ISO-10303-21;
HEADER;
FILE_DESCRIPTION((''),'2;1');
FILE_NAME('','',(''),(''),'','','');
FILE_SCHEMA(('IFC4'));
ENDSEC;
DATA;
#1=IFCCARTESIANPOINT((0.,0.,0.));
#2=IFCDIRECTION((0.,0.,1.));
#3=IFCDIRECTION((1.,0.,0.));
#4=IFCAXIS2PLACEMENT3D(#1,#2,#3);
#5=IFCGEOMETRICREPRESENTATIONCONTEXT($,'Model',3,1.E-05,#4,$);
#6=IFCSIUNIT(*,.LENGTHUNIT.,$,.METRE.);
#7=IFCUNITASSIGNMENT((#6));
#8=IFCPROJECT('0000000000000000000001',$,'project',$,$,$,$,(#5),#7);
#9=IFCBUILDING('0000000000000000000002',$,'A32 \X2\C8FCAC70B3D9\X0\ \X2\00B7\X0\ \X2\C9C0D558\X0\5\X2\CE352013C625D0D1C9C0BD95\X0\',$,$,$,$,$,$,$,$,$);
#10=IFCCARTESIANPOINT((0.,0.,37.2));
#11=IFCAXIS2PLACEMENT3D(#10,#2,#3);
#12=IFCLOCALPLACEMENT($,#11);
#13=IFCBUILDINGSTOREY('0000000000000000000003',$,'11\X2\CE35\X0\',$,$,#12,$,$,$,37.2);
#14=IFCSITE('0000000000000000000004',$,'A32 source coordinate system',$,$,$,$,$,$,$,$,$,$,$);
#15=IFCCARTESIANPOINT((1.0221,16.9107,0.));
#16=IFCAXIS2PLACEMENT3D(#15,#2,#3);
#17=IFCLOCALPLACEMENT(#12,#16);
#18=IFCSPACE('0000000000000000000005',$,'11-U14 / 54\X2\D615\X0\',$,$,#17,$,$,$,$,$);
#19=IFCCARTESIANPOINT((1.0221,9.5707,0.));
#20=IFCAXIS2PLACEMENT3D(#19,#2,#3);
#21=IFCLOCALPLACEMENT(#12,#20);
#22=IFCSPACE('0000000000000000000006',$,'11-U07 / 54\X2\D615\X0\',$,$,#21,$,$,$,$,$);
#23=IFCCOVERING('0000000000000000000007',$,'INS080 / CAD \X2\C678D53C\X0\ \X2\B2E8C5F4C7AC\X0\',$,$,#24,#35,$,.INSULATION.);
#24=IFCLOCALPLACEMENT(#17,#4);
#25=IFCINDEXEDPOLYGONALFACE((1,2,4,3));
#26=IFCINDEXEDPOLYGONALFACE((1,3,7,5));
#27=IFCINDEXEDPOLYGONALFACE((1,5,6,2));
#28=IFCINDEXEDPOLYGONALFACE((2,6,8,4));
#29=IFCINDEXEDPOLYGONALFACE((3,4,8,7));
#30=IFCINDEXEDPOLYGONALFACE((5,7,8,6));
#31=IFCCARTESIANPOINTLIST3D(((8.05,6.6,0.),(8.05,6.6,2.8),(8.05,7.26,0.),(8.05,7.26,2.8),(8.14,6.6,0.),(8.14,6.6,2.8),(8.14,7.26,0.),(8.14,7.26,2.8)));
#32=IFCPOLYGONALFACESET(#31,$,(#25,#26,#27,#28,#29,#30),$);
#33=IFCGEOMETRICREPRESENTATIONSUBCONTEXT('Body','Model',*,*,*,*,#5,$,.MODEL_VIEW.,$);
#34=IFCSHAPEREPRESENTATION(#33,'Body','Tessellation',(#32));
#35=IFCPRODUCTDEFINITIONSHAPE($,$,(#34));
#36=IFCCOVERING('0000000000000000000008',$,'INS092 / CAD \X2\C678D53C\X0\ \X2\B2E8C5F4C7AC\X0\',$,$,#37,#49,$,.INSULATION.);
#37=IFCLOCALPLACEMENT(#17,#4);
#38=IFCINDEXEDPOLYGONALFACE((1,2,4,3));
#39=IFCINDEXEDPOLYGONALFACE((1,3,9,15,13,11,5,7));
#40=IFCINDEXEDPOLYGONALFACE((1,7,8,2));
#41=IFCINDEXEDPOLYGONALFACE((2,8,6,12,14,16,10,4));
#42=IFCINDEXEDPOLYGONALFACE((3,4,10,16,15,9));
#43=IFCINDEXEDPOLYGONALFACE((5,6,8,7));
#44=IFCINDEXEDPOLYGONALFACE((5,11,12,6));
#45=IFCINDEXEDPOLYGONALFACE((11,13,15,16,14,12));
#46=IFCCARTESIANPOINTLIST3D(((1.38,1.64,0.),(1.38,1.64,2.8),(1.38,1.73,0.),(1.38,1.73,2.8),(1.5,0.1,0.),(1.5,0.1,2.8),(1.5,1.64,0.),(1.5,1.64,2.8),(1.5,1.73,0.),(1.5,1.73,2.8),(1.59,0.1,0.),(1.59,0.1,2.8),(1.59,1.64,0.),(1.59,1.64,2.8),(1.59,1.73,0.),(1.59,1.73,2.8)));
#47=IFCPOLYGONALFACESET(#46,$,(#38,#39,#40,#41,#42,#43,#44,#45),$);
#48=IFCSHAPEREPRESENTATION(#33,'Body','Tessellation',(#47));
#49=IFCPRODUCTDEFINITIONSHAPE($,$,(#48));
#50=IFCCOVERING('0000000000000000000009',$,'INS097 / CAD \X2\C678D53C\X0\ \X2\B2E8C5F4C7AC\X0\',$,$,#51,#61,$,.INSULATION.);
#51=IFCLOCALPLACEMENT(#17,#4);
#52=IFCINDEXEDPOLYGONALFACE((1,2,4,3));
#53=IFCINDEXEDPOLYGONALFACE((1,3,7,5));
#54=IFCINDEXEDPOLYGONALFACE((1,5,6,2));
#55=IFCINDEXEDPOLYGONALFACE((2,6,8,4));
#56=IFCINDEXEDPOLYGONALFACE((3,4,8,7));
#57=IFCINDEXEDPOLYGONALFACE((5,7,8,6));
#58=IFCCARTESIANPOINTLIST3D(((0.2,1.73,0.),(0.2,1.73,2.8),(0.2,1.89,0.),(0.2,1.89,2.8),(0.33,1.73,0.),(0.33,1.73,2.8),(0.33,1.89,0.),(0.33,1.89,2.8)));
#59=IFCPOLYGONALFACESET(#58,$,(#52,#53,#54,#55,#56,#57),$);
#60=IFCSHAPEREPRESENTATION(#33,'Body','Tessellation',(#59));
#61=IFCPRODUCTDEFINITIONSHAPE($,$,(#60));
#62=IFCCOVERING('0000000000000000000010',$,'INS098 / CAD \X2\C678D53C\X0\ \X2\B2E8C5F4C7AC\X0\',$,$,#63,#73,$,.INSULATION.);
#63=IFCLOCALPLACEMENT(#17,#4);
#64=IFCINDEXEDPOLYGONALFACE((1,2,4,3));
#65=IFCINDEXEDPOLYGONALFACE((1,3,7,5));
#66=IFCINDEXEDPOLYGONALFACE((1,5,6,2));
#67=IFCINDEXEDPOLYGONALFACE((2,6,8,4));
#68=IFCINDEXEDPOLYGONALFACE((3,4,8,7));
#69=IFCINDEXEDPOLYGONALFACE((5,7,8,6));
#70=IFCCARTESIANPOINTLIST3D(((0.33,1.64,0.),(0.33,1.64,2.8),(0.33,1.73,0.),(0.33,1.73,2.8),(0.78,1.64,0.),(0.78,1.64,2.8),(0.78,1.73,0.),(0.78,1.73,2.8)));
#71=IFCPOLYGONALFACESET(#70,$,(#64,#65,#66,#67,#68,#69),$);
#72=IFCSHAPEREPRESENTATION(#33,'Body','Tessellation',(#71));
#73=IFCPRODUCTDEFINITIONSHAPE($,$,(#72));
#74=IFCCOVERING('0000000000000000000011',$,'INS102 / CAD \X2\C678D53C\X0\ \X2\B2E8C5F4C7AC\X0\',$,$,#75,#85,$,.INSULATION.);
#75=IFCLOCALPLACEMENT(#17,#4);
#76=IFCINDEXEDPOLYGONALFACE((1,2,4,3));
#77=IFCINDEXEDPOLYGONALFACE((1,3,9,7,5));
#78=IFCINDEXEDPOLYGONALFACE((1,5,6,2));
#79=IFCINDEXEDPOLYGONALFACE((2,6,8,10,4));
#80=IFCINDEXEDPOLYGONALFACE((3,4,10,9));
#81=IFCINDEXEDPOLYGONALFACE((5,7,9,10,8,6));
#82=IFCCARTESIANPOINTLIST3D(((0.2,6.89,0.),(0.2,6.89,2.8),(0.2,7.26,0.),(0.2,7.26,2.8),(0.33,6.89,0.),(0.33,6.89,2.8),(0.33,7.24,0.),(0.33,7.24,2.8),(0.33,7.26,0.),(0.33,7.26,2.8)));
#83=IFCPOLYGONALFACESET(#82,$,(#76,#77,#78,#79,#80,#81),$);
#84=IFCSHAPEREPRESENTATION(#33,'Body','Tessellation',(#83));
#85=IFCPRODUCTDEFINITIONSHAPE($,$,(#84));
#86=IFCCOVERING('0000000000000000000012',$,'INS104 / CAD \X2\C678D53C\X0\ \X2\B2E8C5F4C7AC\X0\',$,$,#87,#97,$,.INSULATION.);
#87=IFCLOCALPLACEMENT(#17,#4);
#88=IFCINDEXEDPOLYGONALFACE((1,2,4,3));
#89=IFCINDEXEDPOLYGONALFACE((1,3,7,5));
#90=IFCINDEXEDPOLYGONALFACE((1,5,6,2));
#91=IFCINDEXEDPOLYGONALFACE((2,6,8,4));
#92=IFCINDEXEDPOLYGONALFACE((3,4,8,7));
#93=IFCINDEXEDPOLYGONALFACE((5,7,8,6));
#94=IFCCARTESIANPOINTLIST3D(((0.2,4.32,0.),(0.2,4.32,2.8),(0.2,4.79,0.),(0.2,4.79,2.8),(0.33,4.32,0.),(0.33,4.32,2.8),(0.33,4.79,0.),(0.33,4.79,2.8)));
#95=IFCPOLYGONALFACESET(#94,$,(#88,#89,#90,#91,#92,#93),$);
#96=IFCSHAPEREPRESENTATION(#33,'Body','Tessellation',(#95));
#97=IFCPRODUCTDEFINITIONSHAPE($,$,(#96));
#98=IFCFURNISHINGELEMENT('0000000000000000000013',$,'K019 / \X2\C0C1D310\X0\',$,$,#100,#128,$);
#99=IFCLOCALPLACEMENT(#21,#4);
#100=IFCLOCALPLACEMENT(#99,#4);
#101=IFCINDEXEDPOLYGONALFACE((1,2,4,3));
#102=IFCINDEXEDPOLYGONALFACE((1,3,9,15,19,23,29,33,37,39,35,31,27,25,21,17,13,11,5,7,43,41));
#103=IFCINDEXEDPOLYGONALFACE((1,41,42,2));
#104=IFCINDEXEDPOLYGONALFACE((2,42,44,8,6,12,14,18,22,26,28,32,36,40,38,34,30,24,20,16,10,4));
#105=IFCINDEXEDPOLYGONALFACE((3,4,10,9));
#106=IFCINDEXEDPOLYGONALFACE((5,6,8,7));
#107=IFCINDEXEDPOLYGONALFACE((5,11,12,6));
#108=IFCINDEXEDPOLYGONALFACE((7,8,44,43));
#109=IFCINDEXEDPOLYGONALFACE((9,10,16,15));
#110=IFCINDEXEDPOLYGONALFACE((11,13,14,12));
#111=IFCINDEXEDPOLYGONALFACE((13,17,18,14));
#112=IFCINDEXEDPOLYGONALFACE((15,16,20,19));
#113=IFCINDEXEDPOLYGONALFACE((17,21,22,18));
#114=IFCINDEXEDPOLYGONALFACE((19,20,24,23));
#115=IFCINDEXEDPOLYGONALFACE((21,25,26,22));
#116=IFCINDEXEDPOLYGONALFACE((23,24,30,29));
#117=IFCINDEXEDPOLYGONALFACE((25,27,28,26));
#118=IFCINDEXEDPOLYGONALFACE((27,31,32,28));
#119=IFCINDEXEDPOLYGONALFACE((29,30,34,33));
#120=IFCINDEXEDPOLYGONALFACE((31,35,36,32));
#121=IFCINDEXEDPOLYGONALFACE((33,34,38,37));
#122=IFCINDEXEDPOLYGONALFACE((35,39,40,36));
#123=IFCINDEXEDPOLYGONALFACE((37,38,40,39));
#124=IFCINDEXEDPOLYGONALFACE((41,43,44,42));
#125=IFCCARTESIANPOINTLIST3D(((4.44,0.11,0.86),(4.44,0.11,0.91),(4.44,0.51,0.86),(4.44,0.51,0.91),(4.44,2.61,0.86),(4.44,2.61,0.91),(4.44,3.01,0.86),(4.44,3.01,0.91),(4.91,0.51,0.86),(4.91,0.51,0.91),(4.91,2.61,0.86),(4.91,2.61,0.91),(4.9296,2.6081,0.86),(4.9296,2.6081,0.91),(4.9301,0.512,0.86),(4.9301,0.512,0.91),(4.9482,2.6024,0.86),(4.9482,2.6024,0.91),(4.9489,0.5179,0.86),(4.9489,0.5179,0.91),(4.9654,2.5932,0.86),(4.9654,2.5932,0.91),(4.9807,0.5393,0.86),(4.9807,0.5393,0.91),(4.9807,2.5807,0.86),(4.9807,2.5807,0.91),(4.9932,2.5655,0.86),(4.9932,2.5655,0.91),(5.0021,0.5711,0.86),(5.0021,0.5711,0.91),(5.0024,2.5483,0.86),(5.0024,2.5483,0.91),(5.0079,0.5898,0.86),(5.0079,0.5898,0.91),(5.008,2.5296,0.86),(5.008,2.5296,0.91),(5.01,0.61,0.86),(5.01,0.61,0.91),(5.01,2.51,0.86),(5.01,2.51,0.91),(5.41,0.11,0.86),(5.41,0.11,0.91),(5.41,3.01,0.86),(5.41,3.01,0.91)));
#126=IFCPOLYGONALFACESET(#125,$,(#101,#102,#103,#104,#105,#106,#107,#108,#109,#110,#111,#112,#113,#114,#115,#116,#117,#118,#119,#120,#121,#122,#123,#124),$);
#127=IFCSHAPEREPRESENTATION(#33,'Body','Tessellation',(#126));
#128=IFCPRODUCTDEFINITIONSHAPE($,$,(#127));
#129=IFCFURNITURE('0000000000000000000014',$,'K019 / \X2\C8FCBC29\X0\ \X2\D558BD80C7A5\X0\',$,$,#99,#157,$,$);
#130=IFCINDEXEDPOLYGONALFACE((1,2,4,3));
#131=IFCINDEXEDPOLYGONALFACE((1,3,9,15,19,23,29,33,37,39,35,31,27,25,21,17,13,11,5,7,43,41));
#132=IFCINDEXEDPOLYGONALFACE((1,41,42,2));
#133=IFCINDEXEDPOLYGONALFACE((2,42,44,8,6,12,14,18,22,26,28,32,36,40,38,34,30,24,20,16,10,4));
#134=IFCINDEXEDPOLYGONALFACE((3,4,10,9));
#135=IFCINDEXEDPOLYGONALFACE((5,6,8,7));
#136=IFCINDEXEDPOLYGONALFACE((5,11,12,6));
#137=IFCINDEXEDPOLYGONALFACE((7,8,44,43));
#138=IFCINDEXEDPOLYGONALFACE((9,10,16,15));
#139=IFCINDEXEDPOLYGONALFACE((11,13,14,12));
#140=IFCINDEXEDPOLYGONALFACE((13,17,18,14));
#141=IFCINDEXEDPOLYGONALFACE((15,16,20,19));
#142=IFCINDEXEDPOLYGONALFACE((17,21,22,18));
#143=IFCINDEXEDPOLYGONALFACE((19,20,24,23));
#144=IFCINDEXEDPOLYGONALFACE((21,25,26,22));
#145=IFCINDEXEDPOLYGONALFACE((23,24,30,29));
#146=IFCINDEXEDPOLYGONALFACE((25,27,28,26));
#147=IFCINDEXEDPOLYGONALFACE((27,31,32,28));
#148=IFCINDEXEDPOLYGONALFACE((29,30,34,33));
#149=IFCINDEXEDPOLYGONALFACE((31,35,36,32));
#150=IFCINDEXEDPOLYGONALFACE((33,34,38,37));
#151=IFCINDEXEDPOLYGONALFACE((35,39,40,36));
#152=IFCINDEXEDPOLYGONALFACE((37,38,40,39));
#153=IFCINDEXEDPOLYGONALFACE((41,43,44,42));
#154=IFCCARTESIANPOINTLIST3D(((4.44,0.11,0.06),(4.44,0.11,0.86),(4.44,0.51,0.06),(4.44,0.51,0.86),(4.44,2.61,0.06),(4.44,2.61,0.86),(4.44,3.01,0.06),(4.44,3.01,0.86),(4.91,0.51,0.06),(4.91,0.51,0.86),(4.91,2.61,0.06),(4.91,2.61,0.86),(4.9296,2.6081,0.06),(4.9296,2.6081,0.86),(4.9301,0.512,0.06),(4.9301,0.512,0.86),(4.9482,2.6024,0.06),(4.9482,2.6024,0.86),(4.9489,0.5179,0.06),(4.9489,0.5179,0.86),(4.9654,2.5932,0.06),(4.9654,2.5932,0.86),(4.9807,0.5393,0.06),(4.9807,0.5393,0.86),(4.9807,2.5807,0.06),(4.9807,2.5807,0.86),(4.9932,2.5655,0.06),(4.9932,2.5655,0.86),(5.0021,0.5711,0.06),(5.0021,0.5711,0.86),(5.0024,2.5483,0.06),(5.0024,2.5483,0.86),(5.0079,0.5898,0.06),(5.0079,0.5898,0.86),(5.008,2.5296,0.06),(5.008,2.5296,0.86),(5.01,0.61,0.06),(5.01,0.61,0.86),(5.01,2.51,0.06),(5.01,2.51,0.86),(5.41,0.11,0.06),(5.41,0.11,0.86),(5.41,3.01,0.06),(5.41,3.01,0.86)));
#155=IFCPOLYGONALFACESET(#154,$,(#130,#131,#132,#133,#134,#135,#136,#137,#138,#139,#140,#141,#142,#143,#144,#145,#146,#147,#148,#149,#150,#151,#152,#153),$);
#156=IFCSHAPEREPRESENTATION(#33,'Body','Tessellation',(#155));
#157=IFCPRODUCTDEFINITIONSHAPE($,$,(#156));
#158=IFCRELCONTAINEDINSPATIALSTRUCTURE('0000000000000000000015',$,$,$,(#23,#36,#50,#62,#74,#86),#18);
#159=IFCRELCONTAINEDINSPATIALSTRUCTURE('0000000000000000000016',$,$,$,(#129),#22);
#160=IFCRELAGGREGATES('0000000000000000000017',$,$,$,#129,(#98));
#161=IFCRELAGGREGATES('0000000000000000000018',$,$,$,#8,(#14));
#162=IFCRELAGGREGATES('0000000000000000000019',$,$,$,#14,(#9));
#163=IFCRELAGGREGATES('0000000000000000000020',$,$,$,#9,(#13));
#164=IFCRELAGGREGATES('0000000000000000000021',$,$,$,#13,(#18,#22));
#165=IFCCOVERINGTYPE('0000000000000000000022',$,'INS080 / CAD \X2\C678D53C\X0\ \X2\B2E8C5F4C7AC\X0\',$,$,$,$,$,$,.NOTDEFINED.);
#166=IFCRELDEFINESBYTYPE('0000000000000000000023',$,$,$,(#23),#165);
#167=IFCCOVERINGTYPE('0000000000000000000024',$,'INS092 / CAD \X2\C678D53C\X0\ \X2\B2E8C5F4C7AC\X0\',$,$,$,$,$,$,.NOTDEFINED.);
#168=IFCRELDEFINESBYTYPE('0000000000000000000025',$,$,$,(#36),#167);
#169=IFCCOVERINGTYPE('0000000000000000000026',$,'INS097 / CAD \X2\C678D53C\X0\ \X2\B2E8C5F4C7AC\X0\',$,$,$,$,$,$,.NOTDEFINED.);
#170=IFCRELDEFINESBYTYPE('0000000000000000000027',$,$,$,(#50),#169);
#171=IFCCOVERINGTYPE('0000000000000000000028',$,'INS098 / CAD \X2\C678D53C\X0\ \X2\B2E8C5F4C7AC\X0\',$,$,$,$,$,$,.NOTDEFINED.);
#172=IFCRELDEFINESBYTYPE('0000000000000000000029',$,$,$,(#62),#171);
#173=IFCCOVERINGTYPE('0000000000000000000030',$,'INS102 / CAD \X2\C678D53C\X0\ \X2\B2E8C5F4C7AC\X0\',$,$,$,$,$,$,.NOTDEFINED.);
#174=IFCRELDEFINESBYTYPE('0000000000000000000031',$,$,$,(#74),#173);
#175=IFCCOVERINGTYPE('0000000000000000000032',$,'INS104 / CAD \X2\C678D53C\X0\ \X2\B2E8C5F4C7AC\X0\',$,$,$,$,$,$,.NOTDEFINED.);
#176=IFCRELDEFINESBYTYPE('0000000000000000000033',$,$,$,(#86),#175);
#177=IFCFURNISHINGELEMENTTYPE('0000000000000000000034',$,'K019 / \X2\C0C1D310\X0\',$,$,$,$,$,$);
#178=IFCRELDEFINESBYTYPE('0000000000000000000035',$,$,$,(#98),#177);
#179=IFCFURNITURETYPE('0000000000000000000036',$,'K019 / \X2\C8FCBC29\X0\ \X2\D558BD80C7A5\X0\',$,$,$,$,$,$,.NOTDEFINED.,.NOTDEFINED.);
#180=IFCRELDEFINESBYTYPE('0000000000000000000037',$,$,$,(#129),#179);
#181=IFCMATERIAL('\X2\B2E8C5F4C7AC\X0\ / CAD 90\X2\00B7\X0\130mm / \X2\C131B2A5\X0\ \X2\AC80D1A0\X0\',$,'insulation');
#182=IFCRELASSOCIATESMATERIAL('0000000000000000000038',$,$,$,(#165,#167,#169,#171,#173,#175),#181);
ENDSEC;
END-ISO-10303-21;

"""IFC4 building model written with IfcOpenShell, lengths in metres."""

from ifc_helpers import new_model, si_unit, frame, origin, origin_with_axes, place, context, subcontext, project, spatial, polyline, outline, extrude, source, transform, mapped, material, type_object, type_shapes, element, aggregate, save


model = new_model("IFC4")

# Units and contexts
model_context = context("Model", 3, precision=1e-05, world=origin_with_axes())
body_context = subcontext(model_context, "Body", "Model", "MODEL_VIEW")
ifc_project = project(units=[si_unit("LENGTHUNIT", "METRE")], contexts=[model_context])

# Site, building, storey, space
storey_placement = place(None, frame((0.0, 0.0, 37.2), z_axis=(0.0, 0.0, 1.0), x_axis=(1.0, 0.0, 0.0)))
space_1_placement = place(storey_placement, frame((1.0221, 16.9107, 0.0), z_axis=(0.0, 0.0, 1.0), x_axis=(1.0, 0.0, 0.0)))
site = spatial("IfcSite", under=ifc_project, Name="A32 source coordinate system")
building = spatial("IfcBuilding", under=site, Name="A32 주거동 · 지하5층–옥탑지붕")
storey = spatial("IfcBuildingStorey", under=building, at=storey_placement, Name="11층", Elevation=37.2)
space_1 = spatial("IfcSpace", under=storey, at=space_1_placement, Name="11-U14 / 54형")

# Coverings
ifc_material = material(Name="단열재 / CAD 90·130mm / 성능 검토", Category="insulation")
covering_type_1 = type_object("IfcCoveringType", Name="INS080 / CAD 외피 단열재", PredefinedType="NOTDEFINED", material=ifc_material)
shared_shape_1 = source(origin(), body_context, "Body", "SweptSolid", [
    extrude(outline(polyline([(8.14, 7.26), (8.14, 6.6), (8.05, 6.6), (8.05, 7.26), (8.14, 7.26)])), origin(), (0.0, 0.0, 1.0), 2.8),
])
type_shapes(covering_type_1, [shared_shape_1])
covering_1_placement = place(space_1_placement, origin_with_axes())
element("IfcCovering", 1, at=covering_1_placement, inside=space_1, type_object=covering_type_1, Name="INS080 / CAD 외피 단열재", PredefinedType="INSULATION", context=body_context, shape_type="MappedRepresentation", body=[
    mapped(shared_shape_1, transform((0.0, 0.0, 0.0), scale=1.0)),
])
covering_type_2 = type_object("IfcCoveringType", Name="INS092 / CAD 외피 단열재", PredefinedType="NOTDEFINED", material=ifc_material)
shared_shape_2 = source(origin(), body_context, "Body", "SweptSolid", [
    extrude(outline(polyline([(1.59, 1.73), (1.59, 1.64), (1.59, 0.1), (1.5, 0.1), (1.5, 1.64), (1.38, 1.64), (1.38, 1.73), (1.5, 1.73), (1.59, 1.73)])), origin(), (0.0, 0.0, 1.0), 2.8),
])
type_shapes(covering_type_2, [shared_shape_2])
covering_2_placement = place(space_1_placement, origin_with_axes())
element("IfcCovering", 2, at=covering_2_placement, inside=space_1, type_object=covering_type_2, Name="INS092 / CAD 외피 단열재", PredefinedType="INSULATION", context=body_context, shape_type="MappedRepresentation", body=[
    mapped(shared_shape_2, transform((0.0, 0.0, 0.0), scale=1.0)),
])
covering_type_3 = type_object("IfcCoveringType", Name="INS097 / CAD 외피 단열재", PredefinedType="NOTDEFINED", material=ifc_material)
shared_shape_3 = source(origin(), body_context, "Body", "SweptSolid", [
    extrude(outline(polyline([(0.33, 1.89), (0.33, 1.73), (0.2, 1.73), (0.2, 1.89), (0.33, 1.89)])), origin(), (0.0, 0.0, 1.0), 2.8),
])
type_shapes(covering_type_3, [shared_shape_3])
covering_3_placement = place(space_1_placement, origin_with_axes())
element("IfcCovering", 3, at=covering_3_placement, inside=space_1, type_object=covering_type_3, Name="INS097 / CAD 외피 단열재", PredefinedType="INSULATION", context=body_context, shape_type="MappedRepresentation", body=[
    mapped(shared_shape_3, transform((0.0, 0.0, 0.0), scale=1.0)),
])
covering_type_4 = type_object("IfcCoveringType", Name="INS098 / CAD 외피 단열재", PredefinedType="NOTDEFINED", material=ifc_material)
shared_shape_4 = source(origin(), body_context, "Body", "SweptSolid", [
    extrude(outline(polyline([(0.78, 1.73), (0.78, 1.64), (0.33, 1.64), (0.33, 1.73), (0.78, 1.73)])), origin(), (0.0, 0.0, 1.0), 2.8),
])
type_shapes(covering_type_4, [shared_shape_4])
covering_4_placement = place(space_1_placement, origin_with_axes())
element("IfcCovering", 4, at=covering_4_placement, inside=space_1, type_object=covering_type_4, Name="INS098 / CAD 외피 단열재", PredefinedType="INSULATION", context=body_context, shape_type="MappedRepresentation", body=[
    mapped(shared_shape_4, transform((0.0, 0.0, 0.0), scale=1.0)),
])
covering_type_5 = type_object("IfcCoveringType", Name="INS102 / CAD 외피 단열재", PredefinedType="NOTDEFINED", material=ifc_material)
shared_shape_5 = source(origin(), body_context, "Body", "SweptSolid", [
    extrude(outline(polyline([(0.33, 7.26), (0.33, 7.24), (0.33, 6.89), (0.2, 6.89), (0.2, 7.26), (0.33, 7.26)])), origin(), (0.0, 0.0, 1.0), 2.8),
])
type_shapes(covering_type_5, [shared_shape_5])
covering_5_placement = place(space_1_placement, origin_with_axes())
element("IfcCovering", 5, at=covering_5_placement, inside=space_1, type_object=covering_type_5, Name="INS102 / CAD 외피 단열재", PredefinedType="INSULATION", context=body_context, shape_type="MappedRepresentation", body=[
    mapped(shared_shape_5, transform((0.0, 0.0, 0.0), scale=1.0)),
])
covering_type_6 = type_object("IfcCoveringType", Name="INS104 / CAD 외피 단열재", PredefinedType="NOTDEFINED", material=ifc_material)
shared_shape_6 = source(origin(), body_context, "Body", "SweptSolid", [
    extrude(outline(polyline([(0.33, 4.32), (0.2, 4.32), (0.2, 4.79), (0.33, 4.79), (0.33, 4.32)])), origin(), (0.0, 0.0, 1.0), 2.8),
])
type_shapes(covering_type_6, [shared_shape_6])
covering_6_placement = place(space_1_placement, origin_with_axes())
element("IfcCovering", 6, at=covering_6_placement, inside=space_1, type_object=covering_type_6, Name="INS104 / CAD 외피 단열재", PredefinedType="INSULATION", context=body_context, shape_type="MappedRepresentation", body=[
    mapped(shared_shape_6, transform((0.0, 0.0, 0.0), scale=1.0)),
])

# Furnishing element
furnishing_element_type = type_object("IfcFurnishingElementType", Name="K019 / 상판")
shared_shape_7 = source(origin(), body_context, "Body", "SweptSolid", [
    extrude(outline(polyline([(4.91, 0.51), (4.9301, 0.512), (4.9489, 0.5179), (4.9807, 0.5393), (5.0021, 0.5711), (5.0079, 0.5898), (5.01, 0.61), (5.01, 2.51), (5.008, 2.5296), (5.0024, 2.5483), (4.9932, 2.5655), (4.9807, 2.5807), (4.9654, 2.5932), (4.9482, 2.6024), (4.9296, 2.6081), (4.91, 2.61), (4.44, 2.61), (4.44, 3.01), (5.41, 3.01), (5.41, 0.11), (4.44, 0.11), (4.44, 0.51), (4.91, 0.51)])), frame((0.0, 0.0, 0.86)), (0.0, 0.0, 1.0), 0.05),
])
type_shapes(furnishing_element_type, [shared_shape_7])
space_2_placement = place(storey_placement, frame((1.0221, 9.5707, 0.0), z_axis=(0.0, 0.0, 1.0), x_axis=(1.0, 0.0, 0.0)))
furniture_placement = place(space_2_placement, origin_with_axes())
furnishing_placement = place(furniture_placement, origin_with_axes())
furnishing = element("IfcFurnishingElement", 7, at=furnishing_placement, type_object=furnishing_element_type, Name="K019 / 상판", context=body_context, shape_type="MappedRepresentation", body=[
    mapped(shared_shape_7, transform((0.0, 0.0, 0.0), scale=1.0)),
])

# Shared definitions
space_2 = spatial("IfcSpace", under=storey, at=space_2_placement, Name="11-U07 / 54형")

# Furniture
furniture_type = type_object("IfcFurnitureType", Name="K019 / 주방 하부장", AssemblyPlace="NOTDEFINED", PredefinedType="NOTDEFINED")
shared_shape_8 = source(origin(), body_context, "Body", "SweptSolid", [
    extrude(outline(polyline([(4.44, 0.51), (4.91, 0.51), (4.9301, 0.512), (4.9489, 0.5179), (4.9807, 0.5393), (5.0021, 0.5711), (5.0079, 0.5898), (5.01, 0.61), (5.01, 2.51), (5.008, 2.5296), (5.0024, 2.5483), (4.9932, 2.5655), (4.9807, 2.5807), (4.9654, 2.5932), (4.9482, 2.6024), (4.9296, 2.6081), (4.91, 2.61), (4.44, 2.61), (4.44, 3.01), (5.41, 3.01), (5.41, 0.11), (4.44, 0.11), (4.44, 0.51)])), frame((0.0, 0.0, 0.06)), (0.0, 0.0, 1.0), 0.8),
])
type_shapes(furniture_type, [shared_shape_8])
furniture = element("IfcFurniture", 8, at=furniture_placement, inside=space_2, type_object=furniture_type, Name="K019 / 주방 하부장", context=body_context, shape_type="MappedRepresentation", body=[
    mapped(shared_shape_8, transform((0.0, 0.0, 0.0), scale=1.0)),
])
aggregate(furniture, [furnishing])

save(model, "model.ifc")
